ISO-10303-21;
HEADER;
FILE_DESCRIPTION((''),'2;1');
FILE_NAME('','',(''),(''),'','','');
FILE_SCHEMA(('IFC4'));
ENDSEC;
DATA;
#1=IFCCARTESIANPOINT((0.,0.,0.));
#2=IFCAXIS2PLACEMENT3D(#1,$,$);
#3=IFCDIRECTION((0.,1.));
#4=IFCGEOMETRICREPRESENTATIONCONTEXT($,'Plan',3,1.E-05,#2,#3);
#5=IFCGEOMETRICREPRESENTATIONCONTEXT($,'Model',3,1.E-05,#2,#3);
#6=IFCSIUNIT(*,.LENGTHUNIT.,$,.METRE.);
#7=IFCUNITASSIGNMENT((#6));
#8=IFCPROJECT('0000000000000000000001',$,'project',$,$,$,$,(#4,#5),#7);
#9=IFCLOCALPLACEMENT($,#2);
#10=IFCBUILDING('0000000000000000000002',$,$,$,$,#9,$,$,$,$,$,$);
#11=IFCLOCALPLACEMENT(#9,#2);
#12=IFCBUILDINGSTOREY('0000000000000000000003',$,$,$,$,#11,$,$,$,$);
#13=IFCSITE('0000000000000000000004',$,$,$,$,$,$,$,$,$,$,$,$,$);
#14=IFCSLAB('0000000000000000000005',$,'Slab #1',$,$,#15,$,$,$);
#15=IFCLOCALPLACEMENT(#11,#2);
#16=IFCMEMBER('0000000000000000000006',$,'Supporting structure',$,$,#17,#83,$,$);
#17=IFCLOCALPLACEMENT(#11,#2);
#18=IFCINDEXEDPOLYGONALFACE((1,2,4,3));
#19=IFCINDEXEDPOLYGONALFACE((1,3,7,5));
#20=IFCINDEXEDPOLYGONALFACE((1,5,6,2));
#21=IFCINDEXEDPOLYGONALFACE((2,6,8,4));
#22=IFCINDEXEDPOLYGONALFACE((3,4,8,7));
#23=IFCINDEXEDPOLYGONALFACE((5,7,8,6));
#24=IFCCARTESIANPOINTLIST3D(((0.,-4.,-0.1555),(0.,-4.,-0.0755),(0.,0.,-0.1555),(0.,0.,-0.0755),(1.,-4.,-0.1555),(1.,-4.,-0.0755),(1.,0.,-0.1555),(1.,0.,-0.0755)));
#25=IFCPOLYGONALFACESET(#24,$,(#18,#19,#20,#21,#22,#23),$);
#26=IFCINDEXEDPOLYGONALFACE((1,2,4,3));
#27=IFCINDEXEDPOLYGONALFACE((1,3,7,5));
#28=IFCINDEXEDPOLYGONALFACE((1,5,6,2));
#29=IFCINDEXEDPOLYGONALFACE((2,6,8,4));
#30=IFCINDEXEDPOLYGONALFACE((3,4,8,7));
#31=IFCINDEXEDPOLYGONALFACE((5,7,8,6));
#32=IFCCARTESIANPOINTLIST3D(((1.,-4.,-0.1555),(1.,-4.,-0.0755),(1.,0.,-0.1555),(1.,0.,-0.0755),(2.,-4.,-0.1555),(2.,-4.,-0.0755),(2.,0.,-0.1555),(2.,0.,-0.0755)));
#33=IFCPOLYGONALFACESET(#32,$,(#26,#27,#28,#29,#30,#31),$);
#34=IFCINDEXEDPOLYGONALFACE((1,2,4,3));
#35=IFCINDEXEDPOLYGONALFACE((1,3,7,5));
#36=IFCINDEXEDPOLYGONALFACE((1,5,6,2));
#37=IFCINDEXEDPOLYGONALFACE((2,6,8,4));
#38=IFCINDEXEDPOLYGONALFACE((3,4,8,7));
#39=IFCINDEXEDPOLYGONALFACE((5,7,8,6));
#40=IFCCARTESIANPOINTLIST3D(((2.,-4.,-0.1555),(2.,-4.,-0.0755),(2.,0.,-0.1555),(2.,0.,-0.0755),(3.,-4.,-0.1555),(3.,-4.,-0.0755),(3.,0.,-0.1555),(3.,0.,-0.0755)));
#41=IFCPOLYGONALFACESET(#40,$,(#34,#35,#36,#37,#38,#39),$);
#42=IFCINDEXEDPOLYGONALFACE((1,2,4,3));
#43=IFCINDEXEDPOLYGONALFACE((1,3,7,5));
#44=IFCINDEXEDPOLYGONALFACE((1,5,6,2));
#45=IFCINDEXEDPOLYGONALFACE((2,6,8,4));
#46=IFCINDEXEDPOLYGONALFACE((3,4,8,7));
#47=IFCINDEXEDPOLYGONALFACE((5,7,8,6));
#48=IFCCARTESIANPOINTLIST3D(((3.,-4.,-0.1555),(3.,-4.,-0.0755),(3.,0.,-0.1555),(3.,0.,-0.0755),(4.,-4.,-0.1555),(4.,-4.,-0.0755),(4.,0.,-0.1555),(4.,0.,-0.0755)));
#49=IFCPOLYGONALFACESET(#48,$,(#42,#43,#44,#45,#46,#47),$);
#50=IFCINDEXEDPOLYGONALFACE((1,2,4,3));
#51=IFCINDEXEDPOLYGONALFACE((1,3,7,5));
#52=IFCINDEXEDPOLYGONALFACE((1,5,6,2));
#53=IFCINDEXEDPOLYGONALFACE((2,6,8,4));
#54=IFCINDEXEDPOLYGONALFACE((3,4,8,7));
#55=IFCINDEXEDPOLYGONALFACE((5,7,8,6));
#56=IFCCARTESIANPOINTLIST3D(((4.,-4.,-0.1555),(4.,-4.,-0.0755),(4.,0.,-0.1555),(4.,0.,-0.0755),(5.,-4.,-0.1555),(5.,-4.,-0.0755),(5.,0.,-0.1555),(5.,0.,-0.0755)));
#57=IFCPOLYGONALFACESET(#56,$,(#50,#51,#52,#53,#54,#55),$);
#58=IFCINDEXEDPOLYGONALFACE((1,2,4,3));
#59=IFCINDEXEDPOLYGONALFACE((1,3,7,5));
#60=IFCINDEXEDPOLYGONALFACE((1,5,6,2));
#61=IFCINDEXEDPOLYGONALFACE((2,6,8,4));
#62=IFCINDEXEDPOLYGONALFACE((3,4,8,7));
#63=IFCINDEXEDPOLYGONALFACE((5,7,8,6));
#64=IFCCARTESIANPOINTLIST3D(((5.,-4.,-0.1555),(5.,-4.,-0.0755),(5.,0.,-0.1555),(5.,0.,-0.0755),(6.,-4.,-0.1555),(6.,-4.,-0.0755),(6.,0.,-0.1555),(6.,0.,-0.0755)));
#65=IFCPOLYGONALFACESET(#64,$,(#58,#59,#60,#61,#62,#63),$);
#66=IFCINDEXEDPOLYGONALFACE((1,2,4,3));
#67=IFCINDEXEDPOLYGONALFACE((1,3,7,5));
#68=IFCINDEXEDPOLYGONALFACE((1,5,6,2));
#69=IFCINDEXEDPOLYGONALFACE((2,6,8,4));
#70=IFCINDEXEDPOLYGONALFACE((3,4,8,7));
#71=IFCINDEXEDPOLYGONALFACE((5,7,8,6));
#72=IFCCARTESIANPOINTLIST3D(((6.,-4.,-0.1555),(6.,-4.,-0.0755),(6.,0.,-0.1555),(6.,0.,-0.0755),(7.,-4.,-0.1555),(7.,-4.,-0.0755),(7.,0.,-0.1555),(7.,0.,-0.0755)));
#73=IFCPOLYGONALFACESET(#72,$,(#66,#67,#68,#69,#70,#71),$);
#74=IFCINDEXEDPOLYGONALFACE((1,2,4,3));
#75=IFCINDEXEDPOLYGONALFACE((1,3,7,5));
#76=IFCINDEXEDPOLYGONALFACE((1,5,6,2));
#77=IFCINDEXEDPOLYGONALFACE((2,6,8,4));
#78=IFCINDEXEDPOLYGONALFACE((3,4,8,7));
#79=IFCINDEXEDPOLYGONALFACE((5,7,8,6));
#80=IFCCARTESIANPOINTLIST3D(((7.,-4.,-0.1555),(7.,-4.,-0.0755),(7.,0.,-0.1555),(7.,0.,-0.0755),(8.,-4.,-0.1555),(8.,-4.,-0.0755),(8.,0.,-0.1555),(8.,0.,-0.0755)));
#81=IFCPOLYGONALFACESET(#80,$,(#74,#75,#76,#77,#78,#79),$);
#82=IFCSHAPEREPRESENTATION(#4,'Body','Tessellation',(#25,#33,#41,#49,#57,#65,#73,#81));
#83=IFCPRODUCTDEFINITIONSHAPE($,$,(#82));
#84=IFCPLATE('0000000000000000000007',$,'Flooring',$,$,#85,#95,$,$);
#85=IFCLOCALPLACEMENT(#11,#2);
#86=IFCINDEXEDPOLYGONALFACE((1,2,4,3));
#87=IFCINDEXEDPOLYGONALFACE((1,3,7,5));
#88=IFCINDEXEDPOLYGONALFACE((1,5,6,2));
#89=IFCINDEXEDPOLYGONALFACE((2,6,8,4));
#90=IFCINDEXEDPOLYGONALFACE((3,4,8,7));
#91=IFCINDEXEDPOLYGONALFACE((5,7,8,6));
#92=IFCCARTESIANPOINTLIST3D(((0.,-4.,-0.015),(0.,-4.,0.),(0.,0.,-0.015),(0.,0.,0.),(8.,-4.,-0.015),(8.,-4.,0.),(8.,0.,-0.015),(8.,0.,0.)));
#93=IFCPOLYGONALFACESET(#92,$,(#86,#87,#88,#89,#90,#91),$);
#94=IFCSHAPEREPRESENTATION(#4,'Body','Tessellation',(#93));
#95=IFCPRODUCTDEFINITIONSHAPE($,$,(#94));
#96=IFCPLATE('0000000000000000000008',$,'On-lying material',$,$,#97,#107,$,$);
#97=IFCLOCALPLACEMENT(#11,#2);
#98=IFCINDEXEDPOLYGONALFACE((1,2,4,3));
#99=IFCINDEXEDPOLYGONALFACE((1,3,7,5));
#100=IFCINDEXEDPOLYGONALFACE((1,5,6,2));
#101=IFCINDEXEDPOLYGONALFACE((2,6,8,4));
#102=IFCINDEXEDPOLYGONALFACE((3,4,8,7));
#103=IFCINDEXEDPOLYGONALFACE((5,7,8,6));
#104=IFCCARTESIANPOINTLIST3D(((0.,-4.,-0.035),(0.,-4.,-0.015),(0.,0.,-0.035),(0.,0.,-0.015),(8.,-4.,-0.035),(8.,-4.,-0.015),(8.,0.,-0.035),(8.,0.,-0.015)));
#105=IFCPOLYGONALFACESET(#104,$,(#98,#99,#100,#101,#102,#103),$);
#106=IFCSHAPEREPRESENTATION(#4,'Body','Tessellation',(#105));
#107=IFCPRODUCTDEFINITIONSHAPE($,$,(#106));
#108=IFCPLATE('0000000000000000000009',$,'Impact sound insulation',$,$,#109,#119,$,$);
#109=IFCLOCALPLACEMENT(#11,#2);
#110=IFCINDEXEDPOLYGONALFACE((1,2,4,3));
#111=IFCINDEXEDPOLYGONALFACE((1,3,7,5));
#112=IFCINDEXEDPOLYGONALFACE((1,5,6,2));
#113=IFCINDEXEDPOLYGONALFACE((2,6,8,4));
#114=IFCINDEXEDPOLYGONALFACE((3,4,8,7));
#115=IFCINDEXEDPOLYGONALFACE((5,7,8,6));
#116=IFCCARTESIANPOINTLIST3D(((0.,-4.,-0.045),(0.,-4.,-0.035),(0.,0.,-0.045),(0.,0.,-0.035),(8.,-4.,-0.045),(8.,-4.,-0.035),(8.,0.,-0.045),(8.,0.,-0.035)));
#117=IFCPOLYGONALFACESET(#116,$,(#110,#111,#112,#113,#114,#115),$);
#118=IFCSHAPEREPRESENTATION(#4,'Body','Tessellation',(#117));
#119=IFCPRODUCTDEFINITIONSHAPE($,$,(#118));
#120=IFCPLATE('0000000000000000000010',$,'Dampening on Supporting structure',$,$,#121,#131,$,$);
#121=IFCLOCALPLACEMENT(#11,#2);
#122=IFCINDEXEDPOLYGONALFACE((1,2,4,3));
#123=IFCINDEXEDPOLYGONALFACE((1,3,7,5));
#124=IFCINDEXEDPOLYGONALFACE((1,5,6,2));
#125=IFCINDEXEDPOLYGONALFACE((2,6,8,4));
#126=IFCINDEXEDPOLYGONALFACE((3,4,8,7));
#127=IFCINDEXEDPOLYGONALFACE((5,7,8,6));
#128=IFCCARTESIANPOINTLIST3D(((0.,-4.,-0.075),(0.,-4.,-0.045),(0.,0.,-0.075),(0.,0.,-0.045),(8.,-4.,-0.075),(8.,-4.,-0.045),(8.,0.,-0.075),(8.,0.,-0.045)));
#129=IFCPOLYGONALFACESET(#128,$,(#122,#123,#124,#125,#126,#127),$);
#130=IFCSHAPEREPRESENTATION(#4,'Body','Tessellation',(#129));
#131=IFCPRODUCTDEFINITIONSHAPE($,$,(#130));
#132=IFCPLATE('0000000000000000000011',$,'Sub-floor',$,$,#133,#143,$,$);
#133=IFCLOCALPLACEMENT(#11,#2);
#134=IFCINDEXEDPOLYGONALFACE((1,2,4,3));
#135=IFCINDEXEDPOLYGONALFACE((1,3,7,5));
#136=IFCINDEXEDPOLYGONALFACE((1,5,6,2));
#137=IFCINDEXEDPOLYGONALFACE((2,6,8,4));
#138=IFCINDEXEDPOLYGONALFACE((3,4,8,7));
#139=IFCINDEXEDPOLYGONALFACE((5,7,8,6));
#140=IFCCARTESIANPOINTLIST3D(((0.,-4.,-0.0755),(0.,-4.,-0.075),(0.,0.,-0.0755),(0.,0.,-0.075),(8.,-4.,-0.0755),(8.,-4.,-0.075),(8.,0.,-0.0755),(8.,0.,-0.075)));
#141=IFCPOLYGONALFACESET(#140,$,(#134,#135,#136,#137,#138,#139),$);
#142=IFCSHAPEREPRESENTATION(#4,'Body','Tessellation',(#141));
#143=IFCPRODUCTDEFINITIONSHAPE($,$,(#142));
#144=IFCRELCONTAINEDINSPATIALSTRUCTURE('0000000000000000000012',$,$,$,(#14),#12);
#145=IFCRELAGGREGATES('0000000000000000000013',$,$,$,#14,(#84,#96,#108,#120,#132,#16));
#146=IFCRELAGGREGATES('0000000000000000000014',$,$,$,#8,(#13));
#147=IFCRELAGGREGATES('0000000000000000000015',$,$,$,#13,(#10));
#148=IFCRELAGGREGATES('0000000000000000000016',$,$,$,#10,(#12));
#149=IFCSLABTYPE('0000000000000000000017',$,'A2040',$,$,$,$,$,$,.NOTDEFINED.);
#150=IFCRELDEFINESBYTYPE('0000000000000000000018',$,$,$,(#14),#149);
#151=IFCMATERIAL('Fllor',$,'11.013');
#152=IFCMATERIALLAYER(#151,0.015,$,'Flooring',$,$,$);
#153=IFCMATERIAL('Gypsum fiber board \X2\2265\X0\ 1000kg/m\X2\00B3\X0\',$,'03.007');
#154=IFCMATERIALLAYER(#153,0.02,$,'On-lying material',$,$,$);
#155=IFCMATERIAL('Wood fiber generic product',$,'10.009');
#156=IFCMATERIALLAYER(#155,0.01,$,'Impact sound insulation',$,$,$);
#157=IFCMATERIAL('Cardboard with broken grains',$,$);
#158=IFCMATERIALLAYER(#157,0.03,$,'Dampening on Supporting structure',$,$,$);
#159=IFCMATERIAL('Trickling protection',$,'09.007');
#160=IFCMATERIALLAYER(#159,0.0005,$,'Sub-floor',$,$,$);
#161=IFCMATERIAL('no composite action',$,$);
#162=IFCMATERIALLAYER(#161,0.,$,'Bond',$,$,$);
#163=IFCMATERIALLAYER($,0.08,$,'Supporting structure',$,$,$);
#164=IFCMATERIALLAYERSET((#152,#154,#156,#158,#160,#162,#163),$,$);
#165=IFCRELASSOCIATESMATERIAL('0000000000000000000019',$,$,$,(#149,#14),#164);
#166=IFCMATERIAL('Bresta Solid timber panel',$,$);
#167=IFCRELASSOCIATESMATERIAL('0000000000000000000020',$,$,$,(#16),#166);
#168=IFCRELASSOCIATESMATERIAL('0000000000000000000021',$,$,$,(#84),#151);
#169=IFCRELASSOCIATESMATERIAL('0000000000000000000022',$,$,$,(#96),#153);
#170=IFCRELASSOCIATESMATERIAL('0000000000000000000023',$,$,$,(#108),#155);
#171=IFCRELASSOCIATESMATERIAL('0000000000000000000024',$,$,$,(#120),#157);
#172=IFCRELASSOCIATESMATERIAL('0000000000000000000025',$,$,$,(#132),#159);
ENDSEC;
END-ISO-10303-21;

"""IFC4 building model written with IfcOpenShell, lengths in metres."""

from ifc_helpers import new_model, si_unit, direction, frame, frame_2d, origin, origin_with_axes, place, context, project, spatial, rectangle, extrude, material, layer, layer_set, type_object, element, aggregate, save


model = new_model("IFC4")

# Units and contexts
plan_context = context("Plan", 3, precision=1e-05, world=origin(), true_north=direction((0.0, 1.0)))
model_context = context("Model", 3, precision=1e-05, world=origin(), true_north=direction((0.0, 1.0)))
ifc_project = project(units=[si_unit("LENGTHUNIT", "METRE")], contexts=[plan_context, model_context])

# Site, building, storey
site = spatial("IfcSite", under=ifc_project)
building_placement = place(None, origin())
building = spatial("IfcBuilding", under=site, at=building_placement)
storey_placement = place(building_placement, origin())
storey = spatial("IfcBuildingStorey", under=building, at=storey_placement)

# Slab, member, plates
ifc_material_1 = material(Name="Fllor", Category="11.013")
ifc_layer_1 = layer(ifc_material_1, 0.015, Name="Flooring")
ifc_material_2 = material(Name="Gypsum fiber board ≥ 1000kg/m³", Category="03.007")
ifc_layer_2 = layer(ifc_material_2, 0.02, Name="On-lying material")
ifc_material_3 = material(Name="Wood fiber generic product", Category="10.009")
ifc_layer_3 = layer(ifc_material_3, 0.01, Name="Impact sound insulation")
ifc_material_4 = material(Name="Cardboard with broken grains")
ifc_layer_4 = layer(ifc_material_4, 0.03, Name="Dampening on Supporting structure")
ifc_material_5 = material(Name="Trickling protection", Category="09.007")
ifc_layer_5 = layer(ifc_material_5, 0.0005, Name="Sub-floor")
ifc_material_6 = material(Name="no composite action")
ifc_layer_6 = layer(ifc_material_6, 0.0, Name="Bond")
ifc_layer_7 = layer(None, 0.08, Name="Supporting structure")
ifc_layer_set = layer_set([ifc_layer_1, ifc_layer_2, ifc_layer_3, ifc_layer_4, ifc_layer_5, ifc_layer_6, ifc_layer_7])
slab_type = type_object("IfcSlabType", Name="A2040", PredefinedType="NOTDEFINED", material=ifc_layer_set)
slab_placement = place(None, frame((0.0, 0.0, 0.0), z_axis=(0.0, 0.0, -1.0), x_axis=(1.0, 0.0, 0.0)))
slab = element("IfcSlab", 1, at=slab_placement, inside=storey, type_object=slab_type, material=ifc_layer_set, Name="Slab #1")
ifc_material_7 = material(Name="Bresta Solid timber panel")
member_placement = place(slab_placement, origin())
member = element("IfcMember", 2, at=member_placement, material=ifc_material_7, Name="Supporting structure", context=plan_context, shape_type="SweptSolid", body=[
    extrude(rectangle(XDim=1.0, YDim=0.08, at=frame_2d((0.5, 0.04), x_axis=(1.0, 0.0))), frame((0.0, 4.0, 0.0755), z_axis=(0.0, -1.0, 0.0), x_axis=(1.0, 0.0, 0.0)), (0.0, 0.0, 1.0), 4.0),
    extrude(rectangle(XDim=1.0, YDim=0.08, at=frame_2d((0.5, 0.04), x_axis=(1.0, 0.0))), frame((1.0, 4.0, 0.0755), z_axis=(0.0, -1.0, 0.0), x_axis=(1.0, 0.0, 0.0)), (0.0, 0.0, 1.0), 4.0),
    extrude(rectangle(XDim=1.0, YDim=0.08, at=frame_2d((0.5, 0.04), x_axis=(1.0, 0.0))), frame((2.0, 4.0, 0.0755), z_axis=(0.0, -1.0, 0.0), x_axis=(1.0, 0.0, 0.0)), (0.0, 0.0, 1.0), 4.0),
    extrude(rectangle(XDim=1.0, YDim=0.08, at=frame_2d((0.5, 0.04), x_axis=(1.0, 0.0))), frame((3.0, 4.0, 0.0755), z_axis=(0.0, -1.0, 0.0), x_axis=(1.0, 0.0, 0.0)), (0.0, 0.0, 1.0), 4.0),
    extrude(rectangle(XDim=1.0, YDim=0.08, at=frame_2d((0.5, 0.04), x_axis=(1.0, 0.0))), frame((4.0, 4.0, 0.0755), z_axis=(0.0, -1.0, 0.0), x_axis=(1.0, 0.0, 0.0)), (0.0, 0.0, 1.0), 4.0),
    extrude(rectangle(XDim=1.0, YDim=0.08, at=frame_2d((0.5, 0.04), x_axis=(1.0, 0.0))), frame((5.0, 4.0, 0.0755), z_axis=(0.0, -1.0, 0.0), x_axis=(1.0, 0.0, 0.0)), (0.0, 0.0, 1.0), 4.0),
    extrude(rectangle(XDim=1.0, YDim=0.08, at=frame_2d((0.5, 0.04), x_axis=(1.0, 0.0))), frame((6.0, 4.0, 0.0755), z_axis=(0.0, -1.0, 0.0), x_axis=(1.0, 0.0, 0.0)), (0.0, 0.0, 1.0), 4.0),
    extrude(rectangle(XDim=1.0, YDim=0.08, at=frame_2d((0.5, 0.04), x_axis=(1.0, 0.0))), frame((7.0, 4.0, 0.0755), z_axis=(0.0, -1.0, 0.0), x_axis=(1.0, 0.0, 0.0)), (0.0, 0.0, 1.0), 4.0),
])
plate_1_placement = place(slab_placement, origin())
plate_1 = element("IfcPlate", 3, at=plate_1_placement, material=ifc_material_1, Name="Flooring", context=plan_context, shape_type="SweptSolid", body=[
    extrude(rectangle(XDim=8.0, YDim=4.0, at=frame_2d((4.0, 2.0), x_axis=(1.0, 0.0))), origin_with_axes(), (0.0, 0.0, 1.0), 0.015),
])
plate_2_placement = place(slab_placement, origin())
plate_2 = element("IfcPlate", 4, at=plate_2_placement, material=ifc_material_2, Name="On-lying material", context=plan_context, shape_type="SweptSolid", body=[
    extrude(rectangle(XDim=8.0, YDim=4.0, at=frame_2d((4.0, 2.0), x_axis=(1.0, 0.0))), frame((0.0, 0.0, 0.015), z_axis=(0.0, 0.0, 1.0), x_axis=(1.0, 0.0, 0.0)), (0.0, 0.0, 1.0), 0.02),
])
plate_3_placement = place(slab_placement, origin())
plate_3 = element("IfcPlate", 5, at=plate_3_placement, material=ifc_material_3, Name="Impact sound insulation", context=plan_context, shape_type="SweptSolid", body=[
    extrude(rectangle(XDim=8.0, YDim=4.0, at=frame_2d((4.0, 2.0), x_axis=(1.0, 0.0))), frame((0.0, 0.0, 0.035), z_axis=(0.0, 0.0, 1.0), x_axis=(1.0, 0.0, 0.0)), (0.0, 0.0, 1.0), 0.01),
])
plate_4_placement = place(slab_placement, origin())
plate_4 = element("IfcPlate", 6, at=plate_4_placement, material=ifc_material_4, Name="Dampening on Supporting structure", context=plan_context, shape_type="SweptSolid", body=[
    extrude(rectangle(XDim=8.0, YDim=4.0, at=frame_2d((4.0, 2.0), x_axis=(1.0, 0.0))), frame((0.0, 0.0, 0.045), z_axis=(0.0, 0.0, 1.0), x_axis=(1.0, 0.0, 0.0)), (0.0, 0.0, 1.0), 0.03),
])
plate_5_placement = place(slab_placement, origin())
plate_5 = element("IfcPlate", 7, at=plate_5_placement, material=ifc_material_5, Name="Sub-floor", context=plan_context, shape_type="SweptSolid", body=[
    extrude(rectangle(XDim=8.0, YDim=4.0, at=frame_2d((4.0, 2.0), x_axis=(1.0, 0.0))), frame((0.0, 0.0, 0.075), z_axis=(0.0, 0.0, 1.0), x_axis=(1.0, 0.0, 0.0)), (0.0, 0.0, 1.0), 0.0005),
])
aggregate(slab, [plate_1, plate_2, plate_3, plate_4, plate_5, member])

save(model, "model.ifc")
